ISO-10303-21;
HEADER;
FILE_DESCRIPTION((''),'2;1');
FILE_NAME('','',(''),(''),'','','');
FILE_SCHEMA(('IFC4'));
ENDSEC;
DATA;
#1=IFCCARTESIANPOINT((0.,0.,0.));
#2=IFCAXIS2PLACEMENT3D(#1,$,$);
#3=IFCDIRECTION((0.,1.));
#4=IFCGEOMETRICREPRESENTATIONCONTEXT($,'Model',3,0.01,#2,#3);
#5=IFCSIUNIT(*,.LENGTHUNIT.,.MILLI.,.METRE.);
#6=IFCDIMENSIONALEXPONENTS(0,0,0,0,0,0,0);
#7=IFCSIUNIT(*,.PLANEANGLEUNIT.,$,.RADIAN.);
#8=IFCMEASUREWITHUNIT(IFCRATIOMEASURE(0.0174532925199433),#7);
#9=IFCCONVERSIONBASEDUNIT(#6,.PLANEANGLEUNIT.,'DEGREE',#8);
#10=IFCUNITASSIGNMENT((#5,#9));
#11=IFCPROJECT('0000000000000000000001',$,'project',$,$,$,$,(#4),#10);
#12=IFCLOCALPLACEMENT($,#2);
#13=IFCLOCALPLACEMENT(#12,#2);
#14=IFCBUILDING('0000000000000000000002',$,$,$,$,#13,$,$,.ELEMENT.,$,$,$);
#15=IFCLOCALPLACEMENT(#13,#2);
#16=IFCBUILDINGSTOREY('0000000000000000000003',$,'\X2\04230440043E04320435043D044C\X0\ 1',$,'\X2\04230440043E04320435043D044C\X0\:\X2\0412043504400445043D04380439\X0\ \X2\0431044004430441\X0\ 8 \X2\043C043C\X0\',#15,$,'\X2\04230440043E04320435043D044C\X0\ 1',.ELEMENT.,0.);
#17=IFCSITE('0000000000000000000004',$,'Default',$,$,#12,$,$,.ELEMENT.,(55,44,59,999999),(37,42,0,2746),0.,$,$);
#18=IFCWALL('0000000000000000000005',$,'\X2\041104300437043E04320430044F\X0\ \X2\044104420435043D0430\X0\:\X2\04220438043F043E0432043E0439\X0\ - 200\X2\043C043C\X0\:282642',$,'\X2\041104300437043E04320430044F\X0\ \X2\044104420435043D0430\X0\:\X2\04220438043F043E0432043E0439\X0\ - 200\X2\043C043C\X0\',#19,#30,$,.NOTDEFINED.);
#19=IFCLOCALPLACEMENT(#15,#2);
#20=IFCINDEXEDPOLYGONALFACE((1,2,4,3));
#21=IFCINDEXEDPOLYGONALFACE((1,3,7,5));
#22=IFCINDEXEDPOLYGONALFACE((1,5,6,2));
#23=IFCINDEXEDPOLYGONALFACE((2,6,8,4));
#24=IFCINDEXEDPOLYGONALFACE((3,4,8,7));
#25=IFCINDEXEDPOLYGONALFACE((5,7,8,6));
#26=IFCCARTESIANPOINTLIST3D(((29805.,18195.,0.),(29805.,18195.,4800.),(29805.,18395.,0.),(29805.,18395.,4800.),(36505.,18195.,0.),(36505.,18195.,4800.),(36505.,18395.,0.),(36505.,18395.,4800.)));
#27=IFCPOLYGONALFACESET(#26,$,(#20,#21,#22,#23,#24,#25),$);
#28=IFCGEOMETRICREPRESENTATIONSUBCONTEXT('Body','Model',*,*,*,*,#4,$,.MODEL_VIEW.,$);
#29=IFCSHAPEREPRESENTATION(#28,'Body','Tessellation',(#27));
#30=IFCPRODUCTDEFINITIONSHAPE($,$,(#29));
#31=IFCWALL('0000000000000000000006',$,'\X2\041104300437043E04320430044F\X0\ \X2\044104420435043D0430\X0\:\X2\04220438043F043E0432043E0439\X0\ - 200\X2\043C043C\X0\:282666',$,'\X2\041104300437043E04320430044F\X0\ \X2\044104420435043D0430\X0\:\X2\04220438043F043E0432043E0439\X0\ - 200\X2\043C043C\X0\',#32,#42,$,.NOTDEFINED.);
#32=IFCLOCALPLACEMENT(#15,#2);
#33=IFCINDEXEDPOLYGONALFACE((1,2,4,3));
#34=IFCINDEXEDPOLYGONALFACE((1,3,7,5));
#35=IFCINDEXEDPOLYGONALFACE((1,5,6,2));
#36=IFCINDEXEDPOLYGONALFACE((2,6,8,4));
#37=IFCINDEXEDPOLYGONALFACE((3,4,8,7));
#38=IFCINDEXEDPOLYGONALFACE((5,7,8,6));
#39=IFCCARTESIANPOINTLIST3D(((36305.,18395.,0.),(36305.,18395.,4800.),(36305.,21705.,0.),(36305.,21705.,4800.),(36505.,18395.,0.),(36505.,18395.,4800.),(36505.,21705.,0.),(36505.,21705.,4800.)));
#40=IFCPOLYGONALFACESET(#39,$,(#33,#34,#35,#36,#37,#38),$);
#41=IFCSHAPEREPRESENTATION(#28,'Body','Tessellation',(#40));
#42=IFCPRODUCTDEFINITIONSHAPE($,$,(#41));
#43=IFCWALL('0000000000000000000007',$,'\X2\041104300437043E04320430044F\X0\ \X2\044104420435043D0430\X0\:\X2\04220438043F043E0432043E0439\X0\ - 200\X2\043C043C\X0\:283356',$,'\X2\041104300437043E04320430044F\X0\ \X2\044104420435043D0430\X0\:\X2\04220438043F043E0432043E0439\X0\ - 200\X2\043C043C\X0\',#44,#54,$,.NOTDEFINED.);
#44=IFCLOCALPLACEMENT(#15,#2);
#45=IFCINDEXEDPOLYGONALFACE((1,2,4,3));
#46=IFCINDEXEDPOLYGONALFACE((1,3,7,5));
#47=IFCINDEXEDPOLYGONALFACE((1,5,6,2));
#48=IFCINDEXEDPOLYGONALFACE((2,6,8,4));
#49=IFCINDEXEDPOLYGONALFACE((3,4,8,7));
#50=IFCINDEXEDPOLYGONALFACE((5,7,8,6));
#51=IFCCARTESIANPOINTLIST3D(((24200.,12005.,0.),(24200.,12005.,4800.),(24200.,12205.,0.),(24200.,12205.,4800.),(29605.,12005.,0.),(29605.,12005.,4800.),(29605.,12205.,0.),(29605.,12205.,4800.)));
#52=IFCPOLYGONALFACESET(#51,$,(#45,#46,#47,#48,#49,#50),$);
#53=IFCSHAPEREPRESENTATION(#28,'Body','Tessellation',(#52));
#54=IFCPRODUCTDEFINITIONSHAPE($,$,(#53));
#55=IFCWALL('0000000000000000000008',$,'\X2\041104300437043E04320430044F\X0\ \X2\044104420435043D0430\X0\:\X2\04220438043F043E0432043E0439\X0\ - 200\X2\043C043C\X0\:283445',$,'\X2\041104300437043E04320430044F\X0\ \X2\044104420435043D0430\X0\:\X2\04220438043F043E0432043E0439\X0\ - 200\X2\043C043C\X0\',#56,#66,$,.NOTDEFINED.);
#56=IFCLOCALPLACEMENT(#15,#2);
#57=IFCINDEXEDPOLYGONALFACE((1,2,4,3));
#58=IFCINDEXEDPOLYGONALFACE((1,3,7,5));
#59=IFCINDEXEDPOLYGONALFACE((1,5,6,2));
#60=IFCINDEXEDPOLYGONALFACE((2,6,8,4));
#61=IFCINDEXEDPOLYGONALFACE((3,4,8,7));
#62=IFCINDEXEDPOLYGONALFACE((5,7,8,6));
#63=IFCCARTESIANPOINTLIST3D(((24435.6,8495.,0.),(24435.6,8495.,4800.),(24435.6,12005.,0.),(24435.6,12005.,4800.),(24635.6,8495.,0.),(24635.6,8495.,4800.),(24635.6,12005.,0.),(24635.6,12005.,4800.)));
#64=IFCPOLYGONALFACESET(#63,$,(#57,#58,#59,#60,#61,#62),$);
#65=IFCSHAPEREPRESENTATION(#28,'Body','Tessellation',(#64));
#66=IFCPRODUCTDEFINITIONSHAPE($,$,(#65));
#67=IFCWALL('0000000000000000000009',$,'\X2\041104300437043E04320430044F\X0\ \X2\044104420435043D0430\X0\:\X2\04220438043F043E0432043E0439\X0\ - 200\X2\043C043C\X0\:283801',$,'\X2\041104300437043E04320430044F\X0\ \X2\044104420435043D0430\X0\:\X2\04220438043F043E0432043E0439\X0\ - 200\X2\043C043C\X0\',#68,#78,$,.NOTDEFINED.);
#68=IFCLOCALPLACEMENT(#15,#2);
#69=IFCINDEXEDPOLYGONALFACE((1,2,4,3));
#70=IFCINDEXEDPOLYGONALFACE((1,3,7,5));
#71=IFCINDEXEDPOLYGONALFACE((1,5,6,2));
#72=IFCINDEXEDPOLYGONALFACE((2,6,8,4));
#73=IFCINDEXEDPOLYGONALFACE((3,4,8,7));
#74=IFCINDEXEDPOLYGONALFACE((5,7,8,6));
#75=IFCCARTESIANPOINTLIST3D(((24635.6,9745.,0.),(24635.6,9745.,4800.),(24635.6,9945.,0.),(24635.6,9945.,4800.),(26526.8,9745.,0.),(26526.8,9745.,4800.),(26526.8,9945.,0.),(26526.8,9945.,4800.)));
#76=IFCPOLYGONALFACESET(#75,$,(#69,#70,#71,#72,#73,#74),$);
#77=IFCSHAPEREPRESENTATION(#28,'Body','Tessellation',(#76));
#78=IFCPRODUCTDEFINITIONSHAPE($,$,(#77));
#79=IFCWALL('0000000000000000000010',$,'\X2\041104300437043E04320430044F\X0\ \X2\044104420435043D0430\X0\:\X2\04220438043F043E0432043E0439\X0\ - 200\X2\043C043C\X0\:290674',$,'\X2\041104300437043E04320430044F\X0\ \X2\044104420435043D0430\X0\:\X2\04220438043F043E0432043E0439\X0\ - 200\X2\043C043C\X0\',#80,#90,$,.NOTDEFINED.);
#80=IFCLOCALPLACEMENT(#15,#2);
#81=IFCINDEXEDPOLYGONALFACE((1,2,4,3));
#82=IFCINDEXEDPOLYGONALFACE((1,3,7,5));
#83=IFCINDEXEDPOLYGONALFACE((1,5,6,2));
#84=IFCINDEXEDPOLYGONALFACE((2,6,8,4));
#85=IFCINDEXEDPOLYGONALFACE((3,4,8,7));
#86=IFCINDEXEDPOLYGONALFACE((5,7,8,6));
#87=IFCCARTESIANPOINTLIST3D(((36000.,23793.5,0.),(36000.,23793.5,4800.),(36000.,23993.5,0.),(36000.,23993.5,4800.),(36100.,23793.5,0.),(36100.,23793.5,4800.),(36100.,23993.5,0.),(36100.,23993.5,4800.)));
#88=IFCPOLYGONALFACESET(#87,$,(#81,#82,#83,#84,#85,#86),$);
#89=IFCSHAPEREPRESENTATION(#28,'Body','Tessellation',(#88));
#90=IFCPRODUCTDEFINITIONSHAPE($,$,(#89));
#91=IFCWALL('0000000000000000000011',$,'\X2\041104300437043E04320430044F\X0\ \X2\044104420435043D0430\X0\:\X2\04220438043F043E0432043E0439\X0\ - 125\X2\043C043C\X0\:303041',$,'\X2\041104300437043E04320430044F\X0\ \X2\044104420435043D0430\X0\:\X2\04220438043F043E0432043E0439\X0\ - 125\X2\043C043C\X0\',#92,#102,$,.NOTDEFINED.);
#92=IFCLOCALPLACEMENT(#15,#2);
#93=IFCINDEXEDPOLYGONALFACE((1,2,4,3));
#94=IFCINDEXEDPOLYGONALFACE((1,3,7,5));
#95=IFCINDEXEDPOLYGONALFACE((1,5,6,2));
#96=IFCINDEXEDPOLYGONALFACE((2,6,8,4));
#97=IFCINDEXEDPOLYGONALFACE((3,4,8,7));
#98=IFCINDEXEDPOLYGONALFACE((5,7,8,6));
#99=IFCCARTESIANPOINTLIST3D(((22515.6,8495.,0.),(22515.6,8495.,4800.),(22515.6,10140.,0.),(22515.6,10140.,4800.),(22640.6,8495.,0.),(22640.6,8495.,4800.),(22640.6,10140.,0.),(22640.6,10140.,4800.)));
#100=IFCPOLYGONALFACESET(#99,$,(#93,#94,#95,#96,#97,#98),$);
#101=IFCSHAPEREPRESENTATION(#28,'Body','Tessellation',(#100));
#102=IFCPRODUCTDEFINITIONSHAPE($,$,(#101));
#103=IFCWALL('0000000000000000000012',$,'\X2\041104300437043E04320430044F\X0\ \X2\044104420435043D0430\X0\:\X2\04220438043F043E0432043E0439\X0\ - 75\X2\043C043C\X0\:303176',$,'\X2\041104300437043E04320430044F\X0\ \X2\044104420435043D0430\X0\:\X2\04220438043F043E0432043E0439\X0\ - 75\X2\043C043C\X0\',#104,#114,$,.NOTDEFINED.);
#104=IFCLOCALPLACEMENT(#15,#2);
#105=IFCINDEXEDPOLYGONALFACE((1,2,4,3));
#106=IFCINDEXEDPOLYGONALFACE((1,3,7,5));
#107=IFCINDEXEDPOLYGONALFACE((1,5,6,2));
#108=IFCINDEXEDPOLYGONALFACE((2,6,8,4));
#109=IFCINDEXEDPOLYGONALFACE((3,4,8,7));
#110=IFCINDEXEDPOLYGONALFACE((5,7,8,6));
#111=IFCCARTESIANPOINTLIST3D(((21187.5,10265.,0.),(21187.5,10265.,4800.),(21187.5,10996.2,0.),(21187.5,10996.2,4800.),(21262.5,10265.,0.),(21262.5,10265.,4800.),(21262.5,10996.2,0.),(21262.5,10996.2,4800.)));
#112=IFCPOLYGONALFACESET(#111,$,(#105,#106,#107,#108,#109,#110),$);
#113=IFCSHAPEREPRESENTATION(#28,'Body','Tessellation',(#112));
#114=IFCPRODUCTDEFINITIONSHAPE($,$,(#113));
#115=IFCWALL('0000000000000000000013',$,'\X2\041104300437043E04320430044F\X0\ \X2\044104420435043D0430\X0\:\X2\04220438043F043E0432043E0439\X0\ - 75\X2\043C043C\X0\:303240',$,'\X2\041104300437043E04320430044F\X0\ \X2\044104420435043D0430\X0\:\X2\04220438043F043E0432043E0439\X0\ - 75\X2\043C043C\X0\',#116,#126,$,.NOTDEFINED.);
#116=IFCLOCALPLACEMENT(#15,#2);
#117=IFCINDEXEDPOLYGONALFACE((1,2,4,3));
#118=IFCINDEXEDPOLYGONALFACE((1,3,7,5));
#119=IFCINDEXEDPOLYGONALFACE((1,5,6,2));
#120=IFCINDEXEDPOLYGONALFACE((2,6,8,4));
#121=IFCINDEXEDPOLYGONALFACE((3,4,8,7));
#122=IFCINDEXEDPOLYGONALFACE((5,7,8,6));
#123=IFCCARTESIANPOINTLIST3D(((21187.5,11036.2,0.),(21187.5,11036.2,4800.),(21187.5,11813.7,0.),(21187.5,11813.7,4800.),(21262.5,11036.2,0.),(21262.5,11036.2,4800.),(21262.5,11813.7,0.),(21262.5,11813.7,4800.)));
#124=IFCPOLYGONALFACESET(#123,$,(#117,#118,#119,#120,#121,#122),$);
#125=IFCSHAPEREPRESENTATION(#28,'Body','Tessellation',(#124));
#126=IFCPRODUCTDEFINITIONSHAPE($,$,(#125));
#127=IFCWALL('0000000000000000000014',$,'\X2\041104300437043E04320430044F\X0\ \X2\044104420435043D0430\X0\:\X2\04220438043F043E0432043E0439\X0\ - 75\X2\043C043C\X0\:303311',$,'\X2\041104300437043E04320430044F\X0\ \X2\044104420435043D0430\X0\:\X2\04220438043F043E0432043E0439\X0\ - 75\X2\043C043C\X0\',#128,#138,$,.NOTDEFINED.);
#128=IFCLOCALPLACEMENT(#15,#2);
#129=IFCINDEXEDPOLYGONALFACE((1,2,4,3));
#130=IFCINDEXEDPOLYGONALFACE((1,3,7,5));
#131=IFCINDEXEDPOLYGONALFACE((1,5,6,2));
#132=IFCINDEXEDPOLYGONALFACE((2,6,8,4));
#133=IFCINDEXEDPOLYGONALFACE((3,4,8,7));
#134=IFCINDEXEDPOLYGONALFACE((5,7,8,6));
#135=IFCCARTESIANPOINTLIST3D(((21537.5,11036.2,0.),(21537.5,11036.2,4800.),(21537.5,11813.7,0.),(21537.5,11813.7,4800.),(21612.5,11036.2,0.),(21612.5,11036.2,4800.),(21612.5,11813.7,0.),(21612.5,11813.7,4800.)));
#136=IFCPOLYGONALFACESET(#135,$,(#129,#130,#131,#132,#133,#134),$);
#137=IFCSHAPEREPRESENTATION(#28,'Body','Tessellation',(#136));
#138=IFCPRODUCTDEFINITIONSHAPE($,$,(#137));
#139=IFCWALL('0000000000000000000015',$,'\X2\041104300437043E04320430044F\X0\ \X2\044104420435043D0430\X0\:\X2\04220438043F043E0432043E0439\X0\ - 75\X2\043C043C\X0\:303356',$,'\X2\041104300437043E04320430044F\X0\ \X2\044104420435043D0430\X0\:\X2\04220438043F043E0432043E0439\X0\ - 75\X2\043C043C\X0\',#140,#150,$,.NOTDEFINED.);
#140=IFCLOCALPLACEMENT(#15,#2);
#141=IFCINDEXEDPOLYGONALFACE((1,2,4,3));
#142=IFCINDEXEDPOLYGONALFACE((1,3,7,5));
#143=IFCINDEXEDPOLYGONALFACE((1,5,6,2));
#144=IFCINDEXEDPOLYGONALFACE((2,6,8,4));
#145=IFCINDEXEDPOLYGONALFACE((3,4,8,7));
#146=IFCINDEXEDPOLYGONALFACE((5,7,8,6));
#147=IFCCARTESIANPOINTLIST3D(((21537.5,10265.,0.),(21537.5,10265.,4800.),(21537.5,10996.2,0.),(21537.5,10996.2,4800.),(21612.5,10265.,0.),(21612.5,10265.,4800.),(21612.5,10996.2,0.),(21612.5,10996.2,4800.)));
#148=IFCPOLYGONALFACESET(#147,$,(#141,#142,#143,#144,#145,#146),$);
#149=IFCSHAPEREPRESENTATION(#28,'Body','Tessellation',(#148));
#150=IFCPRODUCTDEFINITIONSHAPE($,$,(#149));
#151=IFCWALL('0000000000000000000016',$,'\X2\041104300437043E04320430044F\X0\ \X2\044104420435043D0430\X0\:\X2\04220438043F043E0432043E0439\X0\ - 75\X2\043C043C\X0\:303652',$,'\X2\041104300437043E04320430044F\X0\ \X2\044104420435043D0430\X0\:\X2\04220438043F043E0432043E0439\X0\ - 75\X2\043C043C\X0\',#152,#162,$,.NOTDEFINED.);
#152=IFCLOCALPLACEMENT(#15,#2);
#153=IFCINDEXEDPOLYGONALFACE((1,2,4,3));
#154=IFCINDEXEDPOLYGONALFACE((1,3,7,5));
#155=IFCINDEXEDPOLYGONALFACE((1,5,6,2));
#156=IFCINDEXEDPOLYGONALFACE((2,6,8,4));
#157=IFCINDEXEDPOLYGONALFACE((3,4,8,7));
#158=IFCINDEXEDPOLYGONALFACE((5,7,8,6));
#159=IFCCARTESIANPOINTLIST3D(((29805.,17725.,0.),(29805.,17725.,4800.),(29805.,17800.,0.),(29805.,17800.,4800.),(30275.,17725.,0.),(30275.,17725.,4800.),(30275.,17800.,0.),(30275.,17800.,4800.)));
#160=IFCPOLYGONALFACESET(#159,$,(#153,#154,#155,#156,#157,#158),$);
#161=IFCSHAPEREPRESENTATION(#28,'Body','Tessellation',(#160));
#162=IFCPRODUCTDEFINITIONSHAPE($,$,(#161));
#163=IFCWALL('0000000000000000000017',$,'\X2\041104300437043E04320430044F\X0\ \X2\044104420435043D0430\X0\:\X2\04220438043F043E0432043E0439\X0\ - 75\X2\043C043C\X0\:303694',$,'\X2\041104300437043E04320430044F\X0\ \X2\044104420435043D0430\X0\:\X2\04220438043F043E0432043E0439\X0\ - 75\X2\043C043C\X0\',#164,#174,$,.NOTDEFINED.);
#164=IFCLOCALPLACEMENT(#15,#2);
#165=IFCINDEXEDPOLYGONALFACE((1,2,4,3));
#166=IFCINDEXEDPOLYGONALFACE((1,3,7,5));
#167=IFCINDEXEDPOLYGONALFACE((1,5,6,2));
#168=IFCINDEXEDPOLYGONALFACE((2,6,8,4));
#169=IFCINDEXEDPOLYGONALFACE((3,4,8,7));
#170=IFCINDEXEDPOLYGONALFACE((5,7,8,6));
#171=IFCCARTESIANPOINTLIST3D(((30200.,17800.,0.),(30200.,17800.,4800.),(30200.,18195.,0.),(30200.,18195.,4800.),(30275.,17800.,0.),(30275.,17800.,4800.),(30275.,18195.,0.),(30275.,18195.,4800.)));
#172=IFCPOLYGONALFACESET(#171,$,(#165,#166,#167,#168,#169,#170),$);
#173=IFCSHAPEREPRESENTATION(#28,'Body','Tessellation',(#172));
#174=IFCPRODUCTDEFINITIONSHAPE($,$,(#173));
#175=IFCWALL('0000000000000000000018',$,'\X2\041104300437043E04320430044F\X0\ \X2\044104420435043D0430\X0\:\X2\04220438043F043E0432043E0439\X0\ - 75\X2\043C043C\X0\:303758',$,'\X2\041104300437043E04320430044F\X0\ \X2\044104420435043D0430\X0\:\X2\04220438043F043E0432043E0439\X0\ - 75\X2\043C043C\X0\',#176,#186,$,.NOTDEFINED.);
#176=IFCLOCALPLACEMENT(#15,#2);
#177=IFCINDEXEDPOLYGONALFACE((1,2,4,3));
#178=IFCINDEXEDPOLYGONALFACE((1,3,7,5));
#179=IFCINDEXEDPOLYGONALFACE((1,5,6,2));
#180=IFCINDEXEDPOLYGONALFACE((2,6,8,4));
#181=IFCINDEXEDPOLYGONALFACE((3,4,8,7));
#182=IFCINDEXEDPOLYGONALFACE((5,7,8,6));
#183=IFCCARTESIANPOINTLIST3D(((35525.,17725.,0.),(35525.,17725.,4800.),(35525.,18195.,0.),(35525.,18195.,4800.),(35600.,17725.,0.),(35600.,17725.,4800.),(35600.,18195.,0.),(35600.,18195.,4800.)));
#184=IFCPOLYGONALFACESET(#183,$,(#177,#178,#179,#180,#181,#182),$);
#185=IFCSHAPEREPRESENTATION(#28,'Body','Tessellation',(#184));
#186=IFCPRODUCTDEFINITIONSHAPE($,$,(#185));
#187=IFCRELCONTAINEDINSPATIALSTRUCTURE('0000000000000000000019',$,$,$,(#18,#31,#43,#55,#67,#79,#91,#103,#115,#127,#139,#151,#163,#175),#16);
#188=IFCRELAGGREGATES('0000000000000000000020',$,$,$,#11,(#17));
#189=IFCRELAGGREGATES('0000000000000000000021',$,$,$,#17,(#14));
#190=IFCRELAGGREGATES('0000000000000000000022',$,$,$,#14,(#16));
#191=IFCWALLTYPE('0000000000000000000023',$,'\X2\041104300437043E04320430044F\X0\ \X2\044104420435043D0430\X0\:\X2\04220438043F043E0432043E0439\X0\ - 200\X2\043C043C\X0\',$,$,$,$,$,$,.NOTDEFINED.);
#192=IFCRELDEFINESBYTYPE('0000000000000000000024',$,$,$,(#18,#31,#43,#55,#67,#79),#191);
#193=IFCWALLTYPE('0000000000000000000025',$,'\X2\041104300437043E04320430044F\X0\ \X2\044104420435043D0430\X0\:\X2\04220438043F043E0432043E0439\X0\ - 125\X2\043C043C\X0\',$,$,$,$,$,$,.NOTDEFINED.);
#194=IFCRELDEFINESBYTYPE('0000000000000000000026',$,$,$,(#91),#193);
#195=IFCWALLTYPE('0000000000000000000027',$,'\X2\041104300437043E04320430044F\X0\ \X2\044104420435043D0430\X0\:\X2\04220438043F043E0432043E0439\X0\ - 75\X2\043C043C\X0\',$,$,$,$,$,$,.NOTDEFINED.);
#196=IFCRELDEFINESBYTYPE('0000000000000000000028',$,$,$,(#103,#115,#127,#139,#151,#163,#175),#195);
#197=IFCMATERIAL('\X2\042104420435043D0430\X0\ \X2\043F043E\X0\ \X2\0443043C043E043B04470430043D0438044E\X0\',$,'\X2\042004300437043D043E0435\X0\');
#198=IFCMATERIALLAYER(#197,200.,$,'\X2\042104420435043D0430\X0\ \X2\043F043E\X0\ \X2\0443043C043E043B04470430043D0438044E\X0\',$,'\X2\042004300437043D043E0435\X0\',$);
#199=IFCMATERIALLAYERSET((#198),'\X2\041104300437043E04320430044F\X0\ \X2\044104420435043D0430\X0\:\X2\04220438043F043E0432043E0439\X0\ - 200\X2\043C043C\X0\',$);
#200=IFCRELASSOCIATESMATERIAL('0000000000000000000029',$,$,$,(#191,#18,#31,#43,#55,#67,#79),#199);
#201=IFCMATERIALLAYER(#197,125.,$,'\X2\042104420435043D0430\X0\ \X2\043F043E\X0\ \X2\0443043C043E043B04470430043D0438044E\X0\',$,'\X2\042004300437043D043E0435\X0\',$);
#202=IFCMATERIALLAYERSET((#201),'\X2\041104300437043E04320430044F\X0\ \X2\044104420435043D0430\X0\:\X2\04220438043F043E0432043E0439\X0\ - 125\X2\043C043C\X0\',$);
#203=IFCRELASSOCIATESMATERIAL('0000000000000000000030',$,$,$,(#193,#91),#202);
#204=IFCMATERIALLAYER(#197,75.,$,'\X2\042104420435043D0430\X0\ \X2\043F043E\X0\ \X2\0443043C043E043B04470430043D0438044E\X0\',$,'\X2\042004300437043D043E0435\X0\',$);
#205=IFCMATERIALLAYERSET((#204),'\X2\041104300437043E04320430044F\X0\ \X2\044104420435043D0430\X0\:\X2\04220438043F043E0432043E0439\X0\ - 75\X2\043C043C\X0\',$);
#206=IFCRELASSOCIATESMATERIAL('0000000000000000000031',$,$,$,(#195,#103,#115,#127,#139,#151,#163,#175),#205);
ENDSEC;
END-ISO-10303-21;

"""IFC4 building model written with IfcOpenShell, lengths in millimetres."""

from ifc_helpers import new_model, entity, si_unit, converted_unit, direction, frame, frame_2d, origin, place, context, subcontext, project, spatial, rectangle, extrude, material, layer, layer_set, layer_usage, type_object, element, save


model = new_model("IFC4")

# Units and contexts
model_context = context("Model", 3, precision=0.01, world=origin(), true_north=direction((0.0, 1.0)))
body_context = subcontext(model_context, "Body", "Model", "MODEL_VIEW")
ifc_project = project(units=[si_unit("LENGTHUNIT", "METRE", prefix="MILLI"), converted_unit("PLANEANGLEUNIT", "DEGREE", entity("IfcRatioMeasure", 0.0174532925199433), si_unit("PLANEANGLEUNIT", "RADIAN"), dimensions=[0, 0, 0, 0, 0, 0, 0])], contexts=[model_context])

# Site, building, storey
site_placement = place(None, origin())
site = spatial("IfcSite", under=ifc_project, at=site_placement, Name="Default", CompositionType="ELEMENT", RefLatitude=(55, 44, 59, 999999), RefLongitude=(37, 42, 0, 2746), RefElevation=0.0)
building_placement = place(site_placement, origin())
building = spatial("IfcBuilding", under=site, at=building_placement, CompositionType="ELEMENT")
storey_placement = place(building_placement, origin())
storey = spatial("IfcBuildingStorey", under=building, at=storey_placement, Name="Уровень 1", ObjectType="Уровень:Верхний брус 8 мм", LongName="Уровень 1", CompositionType="ELEMENT", Elevation=0.0)

# Walls
ifc_material = material(Name="Стена по умолчанию", Category="Разное")
ifc_layer_1 = layer(ifc_material, 200.0, Name="Стена по умолчанию", Category="Разное")
ifc_layer_set_1 = layer_set([ifc_layer_1], Name="Базовая стена:Типовой - 200мм")
ifc_layer_usage_1 = layer_usage(ifc_layer_set_1, "AXIS2", "NEGATIVE", 100.0)
wall_type_1 = type_object("IfcWallType", Name="Базовая стена:Типовой - 200мм", PredefinedType="NOTDEFINED", material=ifc_layer_set_1)
wall_1_placement = place(storey_placement, frame((29805.0, 18295.0, 0.0)))
element("IfcWall", 1, at=wall_1_placement, inside=storey, type_object=wall_type_1, material=ifc_layer_usage_1, Name="Базовая стена:Типовой - 200мм:282642", ObjectType="Базовая стена:Типовой - 200мм", PredefinedType="NOTDEFINED", context=body_context, shape_type="SweptSolid", body=[
    extrude(rectangle(XDim=6700.0, YDim=200.0, at=frame_2d((3350.0, 0.0), x_axis=(-1.0, 0.0))), origin(), (0.0, 0.0, 1.0), 4800.0),
])
ifc_layer_usage_2 = layer_usage(ifc_layer_set_1, "AXIS2", "NEGATIVE", 100.0)
wall_2_placement = place(storey_placement, frame((36405.0, 18395.0, 0.0), z_axis=(0.0, 0.0, 1.0), x_axis=(0.0, 1.0, 0.0)))
element("IfcWall", 2, at=wall_2_placement, inside=storey, type_object=wall_type_1, material=ifc_layer_usage_2, Name="Базовая стена:Типовой - 200мм:282666", ObjectType="Базовая стена:Типовой - 200мм", PredefinedType="NOTDEFINED", context=body_context, shape_type="SweptSolid", body=[
    extrude(rectangle(XDim=3310.0, YDim=200.0, at=frame_2d((1655.0, 0.0), x_axis=(-1.0, 0.0))), origin(), (0.0, 0.0, 1.0), 4800.0),
])

# Walls
ifc_layer_usage_3 = layer_usage(ifc_layer_set_1, "AXIS2", "NEGATIVE", 100.0)
wall_3_placement = place(storey_placement, frame((24200.0, 12105.0, 0.0)))
element("IfcWall", 3, at=wall_3_placement, inside=storey, type_object=wall_type_1, material=ifc_layer_usage_3, Name="Базовая стена:Типовой - 200мм:283356", ObjectType="Базовая стена:Типовой - 200мм", PredefinedType="NOTDEFINED", context=body_context, shape_type="SweptSolid", body=[
    extrude(rectangle(XDim=5405.0, YDim=200.0, at=frame_2d((2702.5, 0.0), x_axis=(-1.0, 0.0))), origin(), (0.0, 0.0, 1.0), 4800.0),
])
ifc_layer_usage_4 = layer_usage(ifc_layer_set_1, "AXIS2", "NEGATIVE", 100.0)
wall_4_placement = place(storey_placement, frame((24535.6, 12005.0, 0.0), z_axis=(0.0, 0.0, 1.0), x_axis=(0.0, -1.0, 0.0)))
element("IfcWall", 4, at=wall_4_placement, inside=storey, type_object=wall_type_1, material=ifc_layer_usage_4, Name="Базовая стена:Типовой - 200мм:283445", ObjectType="Базовая стена:Типовой - 200мм", PredefinedType="NOTDEFINED", context=body_context, shape_type="SweptSolid", body=[
    extrude(rectangle(XDim=3510.0, YDim=200.0, at=frame_2d((1755.0, 0.0), x_axis=(-1.0, 0.0))), origin(), (0.0, 0.0, 1.0), 4800.0),
])
ifc_layer_usage_5 = layer_usage(ifc_layer_set_1, "AXIS2", "NEGATIVE", 100.0)
wall_5_placement = place(storey_placement, frame((24635.6, 9845.0, 0.0)))
element("IfcWall", 5, at=wall_5_placement, inside=storey, type_object=wall_type_1, material=ifc_layer_usage_5, Name="Базовая стена:Типовой - 200мм:283801", ObjectType="Базовая стена:Типовой - 200мм", PredefinedType="NOTDEFINED", context=body_context, shape_type="SweptSolid", body=[
    extrude(rectangle(XDim=1891.3, YDim=200.0, at=frame_2d((945.6, 0.0), x_axis=(-1.0, 0.0))), origin(), (0.0, 0.0, 1.0), 4800.0),
])
ifc_layer_usage_6 = layer_usage(ifc_layer_set_1, "AXIS2", "NEGATIVE", 100.0)
wall_6_placement = place(storey_placement, frame((36000.0, 23893.5, 0.0)))
element("IfcWall", 6, at=wall_6_placement, inside=storey, type_object=wall_type_1, material=ifc_layer_usage_6, Name="Базовая стена:Типовой - 200мм:290674", ObjectType="Базовая стена:Типовой - 200мм", PredefinedType="NOTDEFINED", context=body_context, shape_type="SweptSolid", body=[
    extrude(rectangle(XDim=100.0, YDim=200.0, at=frame_2d((50.0, 0.0), x_axis=(-1.0, 0.0))), origin(), (0.0, 0.0, 1.0), 4800.0),
])
ifc_layer_2 = layer(ifc_material, 125.0, Name="Стена по умолчанию", Category="Разное")
ifc_layer_set_2 = layer_set([ifc_layer_2], Name="Базовая стена:Типовой - 125мм")
ifc_layer_usage_7 = layer_usage(ifc_layer_set_2, "AXIS2", "NEGATIVE", 62.5)
wall_type_2 = type_object("IfcWallType", Name="Базовая стена:Типовой - 125мм", PredefinedType="NOTDEFINED", material=ifc_layer_set_2)
wall_7_placement = place(storey_placement, frame((22578.1, 10140.0, 0.0), z_axis=(0.0, 0.0, 1.0), x_axis=(0.0, -1.0, 0.0)))
element("IfcWall", 7, at=wall_7_placement, inside=storey, type_object=wall_type_2, material=ifc_layer_usage_7, Name="Базовая стена:Типовой - 125мм:303041", ObjectType="Базовая стена:Типовой - 125мм", PredefinedType="NOTDEFINED", context=body_context, shape_type="SweptSolid", body=[
    extrude(rectangle(XDim=1645.0, YDim=125.0, at=frame_2d((822.5, 0.0), x_axis=(-1.0, 0.0))), origin(), (0.0, 0.0, 1.0), 4800.0),
])
ifc_layer_3 = layer(ifc_material, 75.0, Name="Стена по умолчанию", Category="Разное")
ifc_layer_set_3 = layer_set([ifc_layer_3], Name="Базовая стена:Типовой - 75мм")
ifc_layer_usage_8 = layer_usage(ifc_layer_set_3, "AXIS2", "NEGATIVE", 37.5)
wall_type_3 = type_object("IfcWallType", Name="Базовая стена:Типовой - 75мм", PredefinedType="NOTDEFINED", material=ifc_layer_set_3)
wall_8_placement = place(storey_placement, frame((21225.0, 10265.0, 0.0), z_axis=(0.0, 0.0, 1.0), x_axis=(0.0, 1.0, 0.0)))
element("IfcWall", 8, at=wall_8_placement, inside=storey, type_object=wall_type_3, material=ifc_layer_usage_8, Name="Базовая стена:Типовой - 75мм:303176", ObjectType="Базовая стена:Типовой - 75мм", PredefinedType="NOTDEFINED", context=body_context, shape_type="SweptSolid", body=[
    extrude(rectangle(XDim=731.2, YDim=75.0, at=frame_2d((365.6, 0.0), x_axis=(-1.0, 0.0))), origin(), (0.0, 0.0, 1.0), 4800.0),
])
ifc_layer_usage_9 = layer_usage(ifc_layer_set_3, "AXIS2", "NEGATIVE", 37.5)
wall_9_placement = place(storey_placement, frame((21225.0, 11036.2, 0.0), z_axis=(0.0, 0.0, 1.0), x_axis=(0.0, 1.0, 0.0)))
element("IfcWall", 9, at=wall_9_placement, inside=storey, type_object=wall_type_3, material=ifc_layer_usage_9, Name="Базовая стена:Типовой - 75мм:303240", ObjectType="Базовая стена:Типовой - 75мм", PredefinedType="NOTDEFINED", context=body_context, shape_type="SweptSolid", body=[
    extrude(rectangle(XDim=777.5, YDim=75.0, at=frame_2d((388.7, 0.0), x_axis=(-1.0, 0.0))), origin(), (0.0, 0.0, 1.0), 4800.0),
])
ifc_layer_usage_10 = layer_usage(ifc_layer_set_3, "AXIS2", "NEGATIVE", 37.5)
wall_10_placement = place(storey_placement, frame((21575.0, 11813.7, 0.0), z_axis=(0.0, 0.0, 1.0), x_axis=(0.0, -1.0, 0.0)))
element("IfcWall", 10, at=wall_10_placement, inside=storey, type_object=wall_type_3, material=ifc_layer_usage_10, Name="Базовая стена:Типовой - 75мм:303311", ObjectType="Базовая стена:Типовой - 75мм", PredefinedType="NOTDEFINED", context=body_context, shape_type="SweptSolid", body=[
    extrude(rectangle(XDim=777.5, YDim=75.0, at=frame_2d((388.7, 0.0), x_axis=(-1.0, 0.0))), origin(), (0.0, 0.0, 1.0), 4800.0),
])
ifc_layer_usage_11 = layer_usage(ifc_layer_set_3, "AXIS2", "NEGATIVE", 37.5)
wall_11_placement = place(storey_placement, frame((21575.0, 10996.2, 0.0), z_axis=(0.0, 0.0, 1.0), x_axis=(0.0, -1.0, 0.0)))
element("IfcWall", 11, at=wall_11_placement, inside=storey, type_object=wall_type_3, material=ifc_layer_usage_11, Name="Базовая стена:Типовой - 75мм:303356", ObjectType="Базовая стена:Типовой - 75мм", PredefinedType="NOTDEFINED", context=body_context, shape_type="SweptSolid", body=[
    extrude(rectangle(XDim=731.2, YDim=75.0, at=frame_2d((365.6, 0.0), x_axis=(-1.0, 0.0))), origin(), (0.0, 0.0, 1.0), 4800.0),
])
ifc_layer_usage_12 = layer_usage(ifc_layer_set_3, "AXIS2", "NEGATIVE", 37.5)
wall_12_placement = place(storey_placement, frame((29805.0, 17762.5, 0.0)))
element("IfcWall", 12, at=wall_12_placement, inside=storey, type_object=wall_type_3, material=ifc_layer_usage_12, Name="Базовая стена:Типовой - 75мм:303652", ObjectType="Базовая стена:Типовой - 75мм", PredefinedType="NOTDEFINED", context=body_context, shape_type="SweptSolid", body=[
    extrude(rectangle(XDim=470.0, YDim=75.0, at=frame_2d((235.0, 0.0), x_axis=(-1.0, 0.0))), origin(), (0.0, 0.0, 1.0), 4800.0),
])
ifc_layer_usage_13 = layer_usage(ifc_layer_set_3, "AXIS2", "NEGATIVE", 37.5)
wall_13_placement = place(storey_placement, frame((30237.5, 17800.0, 0.0), z_axis=(0.0, 0.0, 1.0), x_axis=(0.0, 1.0, 0.0)))
element("IfcWall", 13, at=wall_13_placement, inside=storey, type_object=wall_type_3, material=ifc_layer_usage_13, Name="Базовая стена:Типовой - 75мм:303694", ObjectType="Базовая стена:Типовой - 75мм", PredefinedType="NOTDEFINED", context=body_context, shape_type="SweptSolid", body=[
    extrude(rectangle(XDim=395.0, YDim=75.0, at=frame_2d((197.5, 0.0), x_axis=(-1.0, 0.0))), origin(), (0.0, 0.0, 1.0), 4800.0),
])
ifc_layer_usage_14 = layer_usage(ifc_layer_set_3, "AXIS2", "NEGATIVE", 37.5)
wall_14_placement = place(storey_placement, frame((35562.5, 18195.0, 0.0), z_axis=(0.0, 0.0, 1.0), x_axis=(0.0, -1.0, 0.0)))
element("IfcWall", 14, at=wall_14_placement, inside=storey, type_object=wall_type_3, material=ifc_layer_usage_14, Name="Базовая стена:Типовой - 75мм:303758", ObjectType="Базовая стена:Типовой - 75мм", PredefinedType="NOTDEFINED", context=body_context, shape_type="SweptSolid", body=[
    extrude(rectangle(XDim=470.0, YDim=75.0, at=frame_2d((235.0, 0.0), x_axis=(-1.0, 0.0))), origin(), (0.0, 0.0, 1.0), 4800.0),
])

save(model, "model.ifc")
